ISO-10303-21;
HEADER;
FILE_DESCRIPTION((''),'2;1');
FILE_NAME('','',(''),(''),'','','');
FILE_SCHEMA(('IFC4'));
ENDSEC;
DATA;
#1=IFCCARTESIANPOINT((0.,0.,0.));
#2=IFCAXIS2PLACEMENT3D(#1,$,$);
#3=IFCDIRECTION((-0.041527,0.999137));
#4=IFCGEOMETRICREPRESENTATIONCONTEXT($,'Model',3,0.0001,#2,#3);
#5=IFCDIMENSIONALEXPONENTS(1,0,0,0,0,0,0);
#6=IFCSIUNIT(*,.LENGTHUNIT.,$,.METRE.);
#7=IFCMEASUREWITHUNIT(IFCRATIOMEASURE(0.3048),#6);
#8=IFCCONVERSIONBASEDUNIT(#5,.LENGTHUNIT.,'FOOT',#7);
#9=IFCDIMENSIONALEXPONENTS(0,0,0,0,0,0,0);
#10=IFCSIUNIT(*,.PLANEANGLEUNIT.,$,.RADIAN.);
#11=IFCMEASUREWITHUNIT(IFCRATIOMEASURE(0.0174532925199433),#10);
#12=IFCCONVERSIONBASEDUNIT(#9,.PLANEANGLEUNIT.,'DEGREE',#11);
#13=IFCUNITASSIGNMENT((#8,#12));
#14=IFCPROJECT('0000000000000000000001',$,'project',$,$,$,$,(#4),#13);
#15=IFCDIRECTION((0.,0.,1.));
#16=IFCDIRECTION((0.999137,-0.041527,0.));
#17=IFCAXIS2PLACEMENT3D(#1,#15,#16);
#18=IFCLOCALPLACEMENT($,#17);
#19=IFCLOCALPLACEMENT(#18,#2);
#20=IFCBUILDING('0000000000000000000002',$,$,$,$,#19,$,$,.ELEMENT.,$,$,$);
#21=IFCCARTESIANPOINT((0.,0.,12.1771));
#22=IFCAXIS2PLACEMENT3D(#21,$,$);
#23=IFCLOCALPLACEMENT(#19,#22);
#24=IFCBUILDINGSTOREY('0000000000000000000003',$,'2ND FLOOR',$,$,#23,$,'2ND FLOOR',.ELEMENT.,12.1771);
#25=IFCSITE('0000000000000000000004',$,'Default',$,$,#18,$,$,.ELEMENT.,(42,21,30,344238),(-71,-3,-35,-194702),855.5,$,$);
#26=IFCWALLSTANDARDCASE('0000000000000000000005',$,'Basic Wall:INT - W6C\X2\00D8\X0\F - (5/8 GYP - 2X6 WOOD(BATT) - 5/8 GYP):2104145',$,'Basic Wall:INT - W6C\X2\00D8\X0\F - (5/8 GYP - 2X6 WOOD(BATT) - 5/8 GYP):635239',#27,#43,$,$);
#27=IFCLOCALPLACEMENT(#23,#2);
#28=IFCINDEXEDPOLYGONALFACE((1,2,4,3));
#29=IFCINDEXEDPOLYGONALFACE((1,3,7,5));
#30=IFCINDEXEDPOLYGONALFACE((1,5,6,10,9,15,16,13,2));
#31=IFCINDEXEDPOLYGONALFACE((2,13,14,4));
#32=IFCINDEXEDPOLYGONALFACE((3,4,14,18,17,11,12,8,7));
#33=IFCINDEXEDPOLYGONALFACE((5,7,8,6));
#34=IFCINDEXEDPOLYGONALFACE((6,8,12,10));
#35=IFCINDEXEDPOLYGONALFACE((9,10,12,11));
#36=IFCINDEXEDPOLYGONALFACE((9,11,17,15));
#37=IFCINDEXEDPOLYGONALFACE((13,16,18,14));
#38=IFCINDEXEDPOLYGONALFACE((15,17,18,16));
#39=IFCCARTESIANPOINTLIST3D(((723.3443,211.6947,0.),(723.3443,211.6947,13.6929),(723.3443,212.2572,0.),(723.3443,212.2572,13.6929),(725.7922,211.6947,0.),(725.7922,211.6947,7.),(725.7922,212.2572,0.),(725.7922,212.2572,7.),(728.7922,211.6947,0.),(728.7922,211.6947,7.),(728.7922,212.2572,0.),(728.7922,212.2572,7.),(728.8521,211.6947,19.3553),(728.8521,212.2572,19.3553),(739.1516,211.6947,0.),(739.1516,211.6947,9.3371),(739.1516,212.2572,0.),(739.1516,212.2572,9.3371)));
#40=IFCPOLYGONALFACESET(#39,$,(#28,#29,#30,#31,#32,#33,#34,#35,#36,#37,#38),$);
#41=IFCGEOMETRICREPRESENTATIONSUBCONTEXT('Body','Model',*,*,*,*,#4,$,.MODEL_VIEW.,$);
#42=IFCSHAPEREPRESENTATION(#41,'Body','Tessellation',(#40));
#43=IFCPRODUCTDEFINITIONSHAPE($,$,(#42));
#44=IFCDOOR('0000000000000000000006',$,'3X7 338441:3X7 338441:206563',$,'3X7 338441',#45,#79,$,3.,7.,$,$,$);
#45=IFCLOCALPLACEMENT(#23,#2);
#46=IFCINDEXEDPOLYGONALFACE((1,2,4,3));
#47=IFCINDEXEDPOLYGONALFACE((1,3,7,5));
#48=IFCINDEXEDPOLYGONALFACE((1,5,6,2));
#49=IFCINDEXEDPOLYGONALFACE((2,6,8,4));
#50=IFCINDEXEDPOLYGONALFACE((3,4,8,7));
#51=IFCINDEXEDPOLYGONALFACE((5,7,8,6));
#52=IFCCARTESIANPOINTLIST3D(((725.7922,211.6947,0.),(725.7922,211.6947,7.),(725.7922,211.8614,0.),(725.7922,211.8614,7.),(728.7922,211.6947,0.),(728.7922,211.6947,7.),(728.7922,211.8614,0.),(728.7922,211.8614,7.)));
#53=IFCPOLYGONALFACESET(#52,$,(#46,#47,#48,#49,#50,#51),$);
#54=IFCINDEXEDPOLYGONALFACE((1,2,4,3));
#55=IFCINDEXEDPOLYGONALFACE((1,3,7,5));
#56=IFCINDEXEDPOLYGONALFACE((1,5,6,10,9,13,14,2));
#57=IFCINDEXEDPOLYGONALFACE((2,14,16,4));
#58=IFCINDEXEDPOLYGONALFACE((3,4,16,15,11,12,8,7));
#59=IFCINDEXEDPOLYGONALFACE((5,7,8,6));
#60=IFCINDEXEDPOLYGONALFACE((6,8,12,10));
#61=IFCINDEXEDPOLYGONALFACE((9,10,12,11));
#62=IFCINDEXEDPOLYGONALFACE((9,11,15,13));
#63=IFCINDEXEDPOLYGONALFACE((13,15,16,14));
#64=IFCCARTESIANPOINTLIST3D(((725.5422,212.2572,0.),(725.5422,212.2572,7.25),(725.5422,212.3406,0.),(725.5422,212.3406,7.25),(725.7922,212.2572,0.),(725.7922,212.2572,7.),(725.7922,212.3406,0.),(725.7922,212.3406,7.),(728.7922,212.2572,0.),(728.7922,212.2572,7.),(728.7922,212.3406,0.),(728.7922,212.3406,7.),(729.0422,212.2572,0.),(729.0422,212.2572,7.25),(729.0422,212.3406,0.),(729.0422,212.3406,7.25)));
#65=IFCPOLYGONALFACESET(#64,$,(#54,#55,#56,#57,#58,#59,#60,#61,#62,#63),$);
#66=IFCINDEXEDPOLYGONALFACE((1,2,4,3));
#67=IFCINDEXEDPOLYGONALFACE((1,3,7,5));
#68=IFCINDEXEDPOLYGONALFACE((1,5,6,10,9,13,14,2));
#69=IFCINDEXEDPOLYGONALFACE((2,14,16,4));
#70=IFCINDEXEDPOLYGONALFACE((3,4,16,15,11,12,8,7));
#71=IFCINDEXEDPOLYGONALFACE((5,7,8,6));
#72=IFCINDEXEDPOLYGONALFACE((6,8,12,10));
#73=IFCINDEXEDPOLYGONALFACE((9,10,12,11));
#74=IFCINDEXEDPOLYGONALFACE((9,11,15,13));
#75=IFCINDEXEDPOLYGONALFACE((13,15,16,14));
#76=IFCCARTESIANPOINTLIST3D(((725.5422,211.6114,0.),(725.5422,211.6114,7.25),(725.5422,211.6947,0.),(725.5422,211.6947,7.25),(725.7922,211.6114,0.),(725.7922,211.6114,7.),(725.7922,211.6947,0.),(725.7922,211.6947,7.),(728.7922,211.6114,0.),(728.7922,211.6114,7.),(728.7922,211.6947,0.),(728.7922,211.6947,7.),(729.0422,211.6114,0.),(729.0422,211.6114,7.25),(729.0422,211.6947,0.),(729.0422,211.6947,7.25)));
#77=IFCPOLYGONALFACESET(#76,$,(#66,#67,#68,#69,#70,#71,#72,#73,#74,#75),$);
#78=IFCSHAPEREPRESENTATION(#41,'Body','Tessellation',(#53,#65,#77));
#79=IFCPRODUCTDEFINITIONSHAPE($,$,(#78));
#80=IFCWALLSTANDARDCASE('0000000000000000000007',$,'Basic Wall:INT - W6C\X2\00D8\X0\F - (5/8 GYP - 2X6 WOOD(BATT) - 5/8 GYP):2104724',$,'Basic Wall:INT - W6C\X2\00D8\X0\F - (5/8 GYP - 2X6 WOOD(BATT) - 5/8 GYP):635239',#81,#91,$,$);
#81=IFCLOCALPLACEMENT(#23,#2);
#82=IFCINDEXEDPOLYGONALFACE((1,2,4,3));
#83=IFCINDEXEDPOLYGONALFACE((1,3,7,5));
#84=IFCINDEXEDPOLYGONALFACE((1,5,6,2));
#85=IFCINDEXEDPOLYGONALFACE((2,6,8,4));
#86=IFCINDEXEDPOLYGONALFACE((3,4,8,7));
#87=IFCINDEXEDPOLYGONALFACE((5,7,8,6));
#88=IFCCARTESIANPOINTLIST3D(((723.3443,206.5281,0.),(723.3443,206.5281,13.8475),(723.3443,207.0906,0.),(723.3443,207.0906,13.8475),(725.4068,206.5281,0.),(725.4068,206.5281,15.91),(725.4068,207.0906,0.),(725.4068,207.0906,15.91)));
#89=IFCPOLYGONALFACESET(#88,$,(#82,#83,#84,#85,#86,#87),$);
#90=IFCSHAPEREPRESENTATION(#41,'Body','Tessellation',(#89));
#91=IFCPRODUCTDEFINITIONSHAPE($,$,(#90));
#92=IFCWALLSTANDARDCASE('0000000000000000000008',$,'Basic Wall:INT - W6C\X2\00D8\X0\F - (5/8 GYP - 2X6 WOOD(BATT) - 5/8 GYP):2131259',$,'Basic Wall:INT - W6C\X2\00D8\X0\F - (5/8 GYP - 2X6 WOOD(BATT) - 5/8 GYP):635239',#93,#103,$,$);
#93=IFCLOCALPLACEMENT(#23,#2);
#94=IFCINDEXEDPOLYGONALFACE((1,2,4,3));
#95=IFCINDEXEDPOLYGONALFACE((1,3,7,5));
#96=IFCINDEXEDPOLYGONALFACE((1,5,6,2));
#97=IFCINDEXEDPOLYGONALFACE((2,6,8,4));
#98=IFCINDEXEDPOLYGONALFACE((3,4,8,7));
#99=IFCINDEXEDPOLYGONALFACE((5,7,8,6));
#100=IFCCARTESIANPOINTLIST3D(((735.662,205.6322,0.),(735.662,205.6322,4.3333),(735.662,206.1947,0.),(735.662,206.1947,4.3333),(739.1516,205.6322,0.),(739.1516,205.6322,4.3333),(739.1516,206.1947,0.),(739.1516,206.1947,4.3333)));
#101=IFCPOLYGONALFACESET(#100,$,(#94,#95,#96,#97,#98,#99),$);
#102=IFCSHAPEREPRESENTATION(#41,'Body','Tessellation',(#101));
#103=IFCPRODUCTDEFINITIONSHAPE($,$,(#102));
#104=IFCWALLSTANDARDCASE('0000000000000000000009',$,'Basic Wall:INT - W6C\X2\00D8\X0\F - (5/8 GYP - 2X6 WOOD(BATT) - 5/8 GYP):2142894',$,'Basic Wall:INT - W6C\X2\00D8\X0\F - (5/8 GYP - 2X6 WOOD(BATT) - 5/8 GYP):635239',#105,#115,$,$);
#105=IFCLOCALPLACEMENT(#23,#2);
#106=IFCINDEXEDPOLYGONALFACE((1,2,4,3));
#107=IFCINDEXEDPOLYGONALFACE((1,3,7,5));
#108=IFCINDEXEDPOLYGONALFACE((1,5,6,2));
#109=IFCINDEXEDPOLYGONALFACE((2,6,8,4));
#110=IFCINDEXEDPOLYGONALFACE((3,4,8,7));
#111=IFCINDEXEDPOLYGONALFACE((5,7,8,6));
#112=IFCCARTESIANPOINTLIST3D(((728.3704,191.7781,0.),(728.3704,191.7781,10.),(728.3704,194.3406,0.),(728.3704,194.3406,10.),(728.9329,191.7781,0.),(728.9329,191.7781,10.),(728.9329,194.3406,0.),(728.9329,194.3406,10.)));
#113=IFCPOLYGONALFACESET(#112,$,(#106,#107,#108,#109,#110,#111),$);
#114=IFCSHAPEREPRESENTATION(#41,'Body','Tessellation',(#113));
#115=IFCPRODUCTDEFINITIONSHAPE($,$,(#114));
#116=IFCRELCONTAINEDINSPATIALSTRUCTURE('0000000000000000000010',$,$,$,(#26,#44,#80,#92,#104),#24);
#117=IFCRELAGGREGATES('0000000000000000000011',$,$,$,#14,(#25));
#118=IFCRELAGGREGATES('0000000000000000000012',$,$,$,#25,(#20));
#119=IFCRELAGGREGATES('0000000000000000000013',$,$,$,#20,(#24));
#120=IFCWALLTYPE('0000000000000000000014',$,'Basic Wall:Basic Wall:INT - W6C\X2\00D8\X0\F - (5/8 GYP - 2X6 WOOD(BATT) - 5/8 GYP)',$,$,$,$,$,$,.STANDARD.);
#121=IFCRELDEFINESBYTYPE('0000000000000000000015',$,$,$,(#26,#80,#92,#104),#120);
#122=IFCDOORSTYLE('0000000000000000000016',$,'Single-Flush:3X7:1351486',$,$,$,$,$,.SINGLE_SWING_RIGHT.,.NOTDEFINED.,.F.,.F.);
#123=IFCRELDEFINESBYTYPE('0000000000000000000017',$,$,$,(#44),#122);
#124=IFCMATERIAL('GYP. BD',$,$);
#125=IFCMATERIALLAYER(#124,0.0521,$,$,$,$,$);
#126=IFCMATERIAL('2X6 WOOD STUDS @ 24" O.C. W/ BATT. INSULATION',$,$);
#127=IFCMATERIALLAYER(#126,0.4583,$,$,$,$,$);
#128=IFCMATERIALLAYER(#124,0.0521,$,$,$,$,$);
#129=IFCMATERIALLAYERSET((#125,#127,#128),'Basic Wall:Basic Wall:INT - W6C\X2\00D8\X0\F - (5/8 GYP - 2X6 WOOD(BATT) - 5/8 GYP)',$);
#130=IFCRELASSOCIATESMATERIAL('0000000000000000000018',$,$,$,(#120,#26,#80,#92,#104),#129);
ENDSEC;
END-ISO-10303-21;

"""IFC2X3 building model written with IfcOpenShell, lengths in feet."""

from ifc_helpers import new_model, entity, si_unit, converted_unit, direction, frame, frame_2d, origin, origin_2d_with_axis, place, context, subcontext, project, spatial, polyline, rectangle, outline, extrude, clip, halfspace, source, transform, mapped, material, layer, layer_set, layer_usage, type_object, type_shapes, element, fill, save


model = new_model("IFC2X3")

# Units and contexts
model_context = context("Model", 3, precision=0.0001, world=origin(), true_north=direction((-0.041527, 0.999137)))
body_context = subcontext(model_context, "Body", "Model", "MODEL_VIEW")
ifc_project = project(units=[converted_unit("LENGTHUNIT", "FOOT", entity("IfcRatioMeasure", 0.3048), si_unit("LENGTHUNIT", "METRE"), dimensions=[1, 0, 0, 0, 0, 0, 0]), converted_unit("PLANEANGLEUNIT", "DEGREE", entity("IfcRatioMeasure", 0.0174532925199433), si_unit("PLANEANGLEUNIT", "RADIAN"), dimensions=[0, 0, 0, 0, 0, 0, 0])], contexts=[model_context])

# Site, building, storey
site_placement = place(None, frame((0.0, 0.0, 0.0), z_axis=(0.0, 0.0, 1.0), x_axis=(0.999137, -0.041527, 0.0)))
site = spatial("IfcSite", under=ifc_project, at=site_placement, Name="Default", CompositionType="ELEMENT", RefLatitude=(42, 21, 30, 344238), RefLongitude=(-71, -3, -35, -194702), RefElevation=855.5)
building_placement = place(site_placement, origin())
building = spatial("IfcBuilding", under=site, at=building_placement, CompositionType="ELEMENT")
storey_placement = place(building_placement, frame((0.0, 0.0, 12.1771)))
storey = spatial("IfcBuildingStorey", under=building, at=storey_placement, Name="2ND FLOOR", LongName="2ND FLOOR", CompositionType="ELEMENT", Elevation=12.1771)

# Shared definitions
ifc_material_1 = material(Name="GYP. BD")
ifc_layer_1 = layer(ifc_material_1, 0.0521)
ifc_material_2 = material(Name="2X6 WOOD STUDS @ 24\" O.C. W/ BATT. INSULATION")
ifc_layer_2 = layer(ifc_material_2, 0.4583)
ifc_layer_3 = layer(ifc_material_1, 0.0521)
ifc_layer_set_1 = layer_set([ifc_layer_1, ifc_layer_2, ifc_layer_3], Name="Basic Wall:Basic Wall:INT - W6CØF - (5/8 GYP - 2X6 WOOD(BATT) - 5/8 GYP)")
wall_type_1 = type_object("IfcWallType", Name="Basic Wall:Basic Wall:INT - W6CØF - (5/8 GYP - 2X6 WOOD(BATT) - 5/8 GYP)", PredefinedType="STANDARD", material=ifc_layer_set_1)

# Shared definitions
door_style_1 = type_object("IfcDoorStyle", Name="Single-Flush:3X7:1351486", ConstructionType="NOTDEFINED", OperationType="SINGLE_SWING_RIGHT", ParameterTakesPrecedence=False, Sizeable=False)
shared_shape_1 = source(origin(), body_context, "Body", "SweptSolid", [
    extrude(rectangle(XDim=3.0, YDim=0.1667, at=origin_2d_with_axis()), frame((1.5, -0.089, 0.0), z_axis=(0.0, 0.0, 1.0), x_axis=(-1.0, 0.0, 0.0)), (0.0, 0.0, 1.0), 7.0),
    extrude(outline(polyline([(-1.75, -3.5625), (-1.5, -3.5625), (-1.5, 3.4375), (1.5, 3.4375), (1.5, -3.5625), (1.75, -3.5625), (1.75, 3.6875), (-1.75, 3.6875), (-1.75, -3.5625)])), frame((1.5, -0.6515, 3.5625), z_axis=(0.0, 1.0, 0.0), x_axis=(-1.0, 0.0, 0.0)), (0.0, 0.0, 1.0), 0.0833),
    extrude(outline(polyline([(-3.6875, -1.75), (3.5625, -1.75), (3.5625, -1.5), (-3.4375, -1.5), (-3.4375, 1.5), (3.5625, 1.5), (3.5625, 1.75), (-3.6875, 1.75), (-3.6875, -1.75)])), frame((1.5, -0.0056, 3.5625), z_axis=(0.0, 1.0, 0.0), x_axis=(0.0, 0.0, -1.0)), (0.0, 0.0, 1.0), 0.0833),
])
type_shapes(door_style_1, [shared_shape_1])

# Wall, opening, door
ifc_layer_usage_1 = layer_usage(ifc_layer_set_1, "AXIS2", "NEGATIVE", 0.2812)
wall_1_placement = place(storey_placement, frame((739.1516, 211.976, 0.0), z_axis=(0.0, 0.0, 1.0), x_axis=(-1.0, 0.0, 0.0)))
wall_1 = element("IfcWallStandardCase", 1, at=wall_1_placement, inside=storey, type_object=wall_type_1, material=ifc_layer_usage_1, Name="Basic Wall:INT - W6CØF - (5/8 GYP - 2X6 WOOD(BATT) - 5/8 GYP):2104145", ObjectType="Basic Wall:INT - W6CØF - (5/8 GYP - 2X6 WOOD(BATT) - 5/8 GYP):635239", context=body_context, shape_type="Clipping", body=[
    clip(clip(extrude(rectangle(XDim=15.8073, YDim=0.5625, at=frame_2d((7.9036, 0.0), x_axis=(-1.0, 0.0))), origin(), (0.0, 0.0, 1.0), 19.3553), halfspace(frame((10.2995, -0.2812, 19.3553), z_axis=(0.716826, 0.0, 0.697252), x_axis=(0.0, 1.0, 0.0)), False)), halfspace(frame((0.0, -0.2812, 9.3371), z_axis=(-0.697252, 0.0, 0.716826), x_axis=(0.0, 1.0, 0.0)), False)),
])
opening_1_placement = place(wall_1_placement, frame((739.1516, 211.976, 0.0), z_axis=(0.0, 0.0, 1.0), x_axis=(-1.0, 0.0, 0.0)))
opening_1 = element("IfcOpeningElement", 2, at=opening_1_placement, cuts=wall_1, ObjectType="Opening", context=body_context, shape_type="SweptSolid", body=[
    extrude(rectangle(XDim=7.0, YDim=3.0, at=origin_2d_with_axis()), frame((727.2922, 212.2628, 3.5), z_axis=(0.0, -1.0, 0.0), x_axis=(0.0, 0.0, -1.0)), (0.0, 0.0, 1.0), 0.5738),
])
door_1_placement = place(opening_1_placement, frame((728.7922, 211.6891, 0.0), z_axis=(0.0, 0.0, 1.0), x_axis=(-1.0, 0.0, 0.0)))
door_1 = element("IfcDoor", 3, at=door_1_placement, inside=storey, type_object=door_style_1, Name="3X7 338441:3X7 338441:206563", ObjectType="3X7 338441", OverallHeight=3.0, OverallWidth=7.0, context=body_context, shape_type="MappedRepresentation", body=[
    mapped(shared_shape_1, transform((0.0, 0.0, 0.0), scale=1.0)),
])
fill(opening_1, door_1)

# Walls
ifc_layer_usage_2 = layer_usage(ifc_layer_set_1, "AXIS2", "NEGATIVE", 0.2812)
wall_2_placement = place(storey_placement, frame((723.3443, 206.8093, 0.0)))
element("IfcWallStandardCase", 4, at=wall_2_placement, inside=storey, type_object=wall_type_1, material=ifc_layer_usage_2, Name="Basic Wall:INT - W6CØF - (5/8 GYP - 2X6 WOOD(BATT) - 5/8 GYP):2104724", ObjectType="Basic Wall:INT - W6CØF - (5/8 GYP - 2X6 WOOD(BATT) - 5/8 GYP):635239", context=body_context, shape_type="Clipping", body=[
    clip(extrude(rectangle(XDim=2.0625, YDim=0.5625, at=frame_2d((1.0312, 0.0), x_axis=(-1.0, 0.0))), origin(), (0.0, 0.0, 1.0), 15.91), halfspace(frame((0.0, -0.2812, 13.8475), z_axis=(-0.707107, 0.0, 0.707107), x_axis=(0.0, 1.0, 0.0)), False)),
])
ifc_layer_usage_3 = layer_usage(ifc_layer_set_1, "AXIS2", "NEGATIVE", 0.2812)
wall_3_placement = place(storey_placement, frame((739.1516, 205.9135, 0.0), z_axis=(0.0, 0.0, 1.0), x_axis=(-1.0, 0.0, 0.0)))
element("IfcWallStandardCase", 5, at=wall_3_placement, inside=storey, type_object=wall_type_1, material=ifc_layer_usage_3, Name="Basic Wall:INT - W6CØF - (5/8 GYP - 2X6 WOOD(BATT) - 5/8 GYP):2131259", ObjectType="Basic Wall:INT - W6CØF - (5/8 GYP - 2X6 WOOD(BATT) - 5/8 GYP):635239", context=body_context, shape_type="SweptSolid", body=[
    extrude(rectangle(XDim=3.4896, YDim=0.5625, at=frame_2d((1.7448, 0.0), x_axis=(-1.0, 0.0))), origin(), (0.0, 0.0, 1.0), 4.3333),
])
ifc_layer_usage_4 = layer_usage(ifc_layer_set_1, "AXIS2", "NEGATIVE", 0.2812)
wall_4_placement = place(storey_placement, frame((728.6516, 194.3406, 0.0), z_axis=(0.0, 0.0, 1.0), x_axis=(0.0, -1.0, 0.0)))
element("IfcWallStandardCase", 6, at=wall_4_placement, inside=storey, type_object=wall_type_1, material=ifc_layer_usage_4, Name="Basic Wall:INT - W6CØF - (5/8 GYP - 2X6 WOOD(BATT) - 5/8 GYP):2142894", ObjectType="Basic Wall:INT - W6CØF - (5/8 GYP - 2X6 WOOD(BATT) - 5/8 GYP):635239", context=body_context, shape_type="SweptSolid", body=[
    extrude(rectangle(XDim=2.5625, YDim=0.5625, at=frame_2d((1.2812, 0.0), x_axis=(-1.0, 0.0))), origin(), (0.0, 0.0, 1.0), 10.0),
])

save(model, "model.ifc")
